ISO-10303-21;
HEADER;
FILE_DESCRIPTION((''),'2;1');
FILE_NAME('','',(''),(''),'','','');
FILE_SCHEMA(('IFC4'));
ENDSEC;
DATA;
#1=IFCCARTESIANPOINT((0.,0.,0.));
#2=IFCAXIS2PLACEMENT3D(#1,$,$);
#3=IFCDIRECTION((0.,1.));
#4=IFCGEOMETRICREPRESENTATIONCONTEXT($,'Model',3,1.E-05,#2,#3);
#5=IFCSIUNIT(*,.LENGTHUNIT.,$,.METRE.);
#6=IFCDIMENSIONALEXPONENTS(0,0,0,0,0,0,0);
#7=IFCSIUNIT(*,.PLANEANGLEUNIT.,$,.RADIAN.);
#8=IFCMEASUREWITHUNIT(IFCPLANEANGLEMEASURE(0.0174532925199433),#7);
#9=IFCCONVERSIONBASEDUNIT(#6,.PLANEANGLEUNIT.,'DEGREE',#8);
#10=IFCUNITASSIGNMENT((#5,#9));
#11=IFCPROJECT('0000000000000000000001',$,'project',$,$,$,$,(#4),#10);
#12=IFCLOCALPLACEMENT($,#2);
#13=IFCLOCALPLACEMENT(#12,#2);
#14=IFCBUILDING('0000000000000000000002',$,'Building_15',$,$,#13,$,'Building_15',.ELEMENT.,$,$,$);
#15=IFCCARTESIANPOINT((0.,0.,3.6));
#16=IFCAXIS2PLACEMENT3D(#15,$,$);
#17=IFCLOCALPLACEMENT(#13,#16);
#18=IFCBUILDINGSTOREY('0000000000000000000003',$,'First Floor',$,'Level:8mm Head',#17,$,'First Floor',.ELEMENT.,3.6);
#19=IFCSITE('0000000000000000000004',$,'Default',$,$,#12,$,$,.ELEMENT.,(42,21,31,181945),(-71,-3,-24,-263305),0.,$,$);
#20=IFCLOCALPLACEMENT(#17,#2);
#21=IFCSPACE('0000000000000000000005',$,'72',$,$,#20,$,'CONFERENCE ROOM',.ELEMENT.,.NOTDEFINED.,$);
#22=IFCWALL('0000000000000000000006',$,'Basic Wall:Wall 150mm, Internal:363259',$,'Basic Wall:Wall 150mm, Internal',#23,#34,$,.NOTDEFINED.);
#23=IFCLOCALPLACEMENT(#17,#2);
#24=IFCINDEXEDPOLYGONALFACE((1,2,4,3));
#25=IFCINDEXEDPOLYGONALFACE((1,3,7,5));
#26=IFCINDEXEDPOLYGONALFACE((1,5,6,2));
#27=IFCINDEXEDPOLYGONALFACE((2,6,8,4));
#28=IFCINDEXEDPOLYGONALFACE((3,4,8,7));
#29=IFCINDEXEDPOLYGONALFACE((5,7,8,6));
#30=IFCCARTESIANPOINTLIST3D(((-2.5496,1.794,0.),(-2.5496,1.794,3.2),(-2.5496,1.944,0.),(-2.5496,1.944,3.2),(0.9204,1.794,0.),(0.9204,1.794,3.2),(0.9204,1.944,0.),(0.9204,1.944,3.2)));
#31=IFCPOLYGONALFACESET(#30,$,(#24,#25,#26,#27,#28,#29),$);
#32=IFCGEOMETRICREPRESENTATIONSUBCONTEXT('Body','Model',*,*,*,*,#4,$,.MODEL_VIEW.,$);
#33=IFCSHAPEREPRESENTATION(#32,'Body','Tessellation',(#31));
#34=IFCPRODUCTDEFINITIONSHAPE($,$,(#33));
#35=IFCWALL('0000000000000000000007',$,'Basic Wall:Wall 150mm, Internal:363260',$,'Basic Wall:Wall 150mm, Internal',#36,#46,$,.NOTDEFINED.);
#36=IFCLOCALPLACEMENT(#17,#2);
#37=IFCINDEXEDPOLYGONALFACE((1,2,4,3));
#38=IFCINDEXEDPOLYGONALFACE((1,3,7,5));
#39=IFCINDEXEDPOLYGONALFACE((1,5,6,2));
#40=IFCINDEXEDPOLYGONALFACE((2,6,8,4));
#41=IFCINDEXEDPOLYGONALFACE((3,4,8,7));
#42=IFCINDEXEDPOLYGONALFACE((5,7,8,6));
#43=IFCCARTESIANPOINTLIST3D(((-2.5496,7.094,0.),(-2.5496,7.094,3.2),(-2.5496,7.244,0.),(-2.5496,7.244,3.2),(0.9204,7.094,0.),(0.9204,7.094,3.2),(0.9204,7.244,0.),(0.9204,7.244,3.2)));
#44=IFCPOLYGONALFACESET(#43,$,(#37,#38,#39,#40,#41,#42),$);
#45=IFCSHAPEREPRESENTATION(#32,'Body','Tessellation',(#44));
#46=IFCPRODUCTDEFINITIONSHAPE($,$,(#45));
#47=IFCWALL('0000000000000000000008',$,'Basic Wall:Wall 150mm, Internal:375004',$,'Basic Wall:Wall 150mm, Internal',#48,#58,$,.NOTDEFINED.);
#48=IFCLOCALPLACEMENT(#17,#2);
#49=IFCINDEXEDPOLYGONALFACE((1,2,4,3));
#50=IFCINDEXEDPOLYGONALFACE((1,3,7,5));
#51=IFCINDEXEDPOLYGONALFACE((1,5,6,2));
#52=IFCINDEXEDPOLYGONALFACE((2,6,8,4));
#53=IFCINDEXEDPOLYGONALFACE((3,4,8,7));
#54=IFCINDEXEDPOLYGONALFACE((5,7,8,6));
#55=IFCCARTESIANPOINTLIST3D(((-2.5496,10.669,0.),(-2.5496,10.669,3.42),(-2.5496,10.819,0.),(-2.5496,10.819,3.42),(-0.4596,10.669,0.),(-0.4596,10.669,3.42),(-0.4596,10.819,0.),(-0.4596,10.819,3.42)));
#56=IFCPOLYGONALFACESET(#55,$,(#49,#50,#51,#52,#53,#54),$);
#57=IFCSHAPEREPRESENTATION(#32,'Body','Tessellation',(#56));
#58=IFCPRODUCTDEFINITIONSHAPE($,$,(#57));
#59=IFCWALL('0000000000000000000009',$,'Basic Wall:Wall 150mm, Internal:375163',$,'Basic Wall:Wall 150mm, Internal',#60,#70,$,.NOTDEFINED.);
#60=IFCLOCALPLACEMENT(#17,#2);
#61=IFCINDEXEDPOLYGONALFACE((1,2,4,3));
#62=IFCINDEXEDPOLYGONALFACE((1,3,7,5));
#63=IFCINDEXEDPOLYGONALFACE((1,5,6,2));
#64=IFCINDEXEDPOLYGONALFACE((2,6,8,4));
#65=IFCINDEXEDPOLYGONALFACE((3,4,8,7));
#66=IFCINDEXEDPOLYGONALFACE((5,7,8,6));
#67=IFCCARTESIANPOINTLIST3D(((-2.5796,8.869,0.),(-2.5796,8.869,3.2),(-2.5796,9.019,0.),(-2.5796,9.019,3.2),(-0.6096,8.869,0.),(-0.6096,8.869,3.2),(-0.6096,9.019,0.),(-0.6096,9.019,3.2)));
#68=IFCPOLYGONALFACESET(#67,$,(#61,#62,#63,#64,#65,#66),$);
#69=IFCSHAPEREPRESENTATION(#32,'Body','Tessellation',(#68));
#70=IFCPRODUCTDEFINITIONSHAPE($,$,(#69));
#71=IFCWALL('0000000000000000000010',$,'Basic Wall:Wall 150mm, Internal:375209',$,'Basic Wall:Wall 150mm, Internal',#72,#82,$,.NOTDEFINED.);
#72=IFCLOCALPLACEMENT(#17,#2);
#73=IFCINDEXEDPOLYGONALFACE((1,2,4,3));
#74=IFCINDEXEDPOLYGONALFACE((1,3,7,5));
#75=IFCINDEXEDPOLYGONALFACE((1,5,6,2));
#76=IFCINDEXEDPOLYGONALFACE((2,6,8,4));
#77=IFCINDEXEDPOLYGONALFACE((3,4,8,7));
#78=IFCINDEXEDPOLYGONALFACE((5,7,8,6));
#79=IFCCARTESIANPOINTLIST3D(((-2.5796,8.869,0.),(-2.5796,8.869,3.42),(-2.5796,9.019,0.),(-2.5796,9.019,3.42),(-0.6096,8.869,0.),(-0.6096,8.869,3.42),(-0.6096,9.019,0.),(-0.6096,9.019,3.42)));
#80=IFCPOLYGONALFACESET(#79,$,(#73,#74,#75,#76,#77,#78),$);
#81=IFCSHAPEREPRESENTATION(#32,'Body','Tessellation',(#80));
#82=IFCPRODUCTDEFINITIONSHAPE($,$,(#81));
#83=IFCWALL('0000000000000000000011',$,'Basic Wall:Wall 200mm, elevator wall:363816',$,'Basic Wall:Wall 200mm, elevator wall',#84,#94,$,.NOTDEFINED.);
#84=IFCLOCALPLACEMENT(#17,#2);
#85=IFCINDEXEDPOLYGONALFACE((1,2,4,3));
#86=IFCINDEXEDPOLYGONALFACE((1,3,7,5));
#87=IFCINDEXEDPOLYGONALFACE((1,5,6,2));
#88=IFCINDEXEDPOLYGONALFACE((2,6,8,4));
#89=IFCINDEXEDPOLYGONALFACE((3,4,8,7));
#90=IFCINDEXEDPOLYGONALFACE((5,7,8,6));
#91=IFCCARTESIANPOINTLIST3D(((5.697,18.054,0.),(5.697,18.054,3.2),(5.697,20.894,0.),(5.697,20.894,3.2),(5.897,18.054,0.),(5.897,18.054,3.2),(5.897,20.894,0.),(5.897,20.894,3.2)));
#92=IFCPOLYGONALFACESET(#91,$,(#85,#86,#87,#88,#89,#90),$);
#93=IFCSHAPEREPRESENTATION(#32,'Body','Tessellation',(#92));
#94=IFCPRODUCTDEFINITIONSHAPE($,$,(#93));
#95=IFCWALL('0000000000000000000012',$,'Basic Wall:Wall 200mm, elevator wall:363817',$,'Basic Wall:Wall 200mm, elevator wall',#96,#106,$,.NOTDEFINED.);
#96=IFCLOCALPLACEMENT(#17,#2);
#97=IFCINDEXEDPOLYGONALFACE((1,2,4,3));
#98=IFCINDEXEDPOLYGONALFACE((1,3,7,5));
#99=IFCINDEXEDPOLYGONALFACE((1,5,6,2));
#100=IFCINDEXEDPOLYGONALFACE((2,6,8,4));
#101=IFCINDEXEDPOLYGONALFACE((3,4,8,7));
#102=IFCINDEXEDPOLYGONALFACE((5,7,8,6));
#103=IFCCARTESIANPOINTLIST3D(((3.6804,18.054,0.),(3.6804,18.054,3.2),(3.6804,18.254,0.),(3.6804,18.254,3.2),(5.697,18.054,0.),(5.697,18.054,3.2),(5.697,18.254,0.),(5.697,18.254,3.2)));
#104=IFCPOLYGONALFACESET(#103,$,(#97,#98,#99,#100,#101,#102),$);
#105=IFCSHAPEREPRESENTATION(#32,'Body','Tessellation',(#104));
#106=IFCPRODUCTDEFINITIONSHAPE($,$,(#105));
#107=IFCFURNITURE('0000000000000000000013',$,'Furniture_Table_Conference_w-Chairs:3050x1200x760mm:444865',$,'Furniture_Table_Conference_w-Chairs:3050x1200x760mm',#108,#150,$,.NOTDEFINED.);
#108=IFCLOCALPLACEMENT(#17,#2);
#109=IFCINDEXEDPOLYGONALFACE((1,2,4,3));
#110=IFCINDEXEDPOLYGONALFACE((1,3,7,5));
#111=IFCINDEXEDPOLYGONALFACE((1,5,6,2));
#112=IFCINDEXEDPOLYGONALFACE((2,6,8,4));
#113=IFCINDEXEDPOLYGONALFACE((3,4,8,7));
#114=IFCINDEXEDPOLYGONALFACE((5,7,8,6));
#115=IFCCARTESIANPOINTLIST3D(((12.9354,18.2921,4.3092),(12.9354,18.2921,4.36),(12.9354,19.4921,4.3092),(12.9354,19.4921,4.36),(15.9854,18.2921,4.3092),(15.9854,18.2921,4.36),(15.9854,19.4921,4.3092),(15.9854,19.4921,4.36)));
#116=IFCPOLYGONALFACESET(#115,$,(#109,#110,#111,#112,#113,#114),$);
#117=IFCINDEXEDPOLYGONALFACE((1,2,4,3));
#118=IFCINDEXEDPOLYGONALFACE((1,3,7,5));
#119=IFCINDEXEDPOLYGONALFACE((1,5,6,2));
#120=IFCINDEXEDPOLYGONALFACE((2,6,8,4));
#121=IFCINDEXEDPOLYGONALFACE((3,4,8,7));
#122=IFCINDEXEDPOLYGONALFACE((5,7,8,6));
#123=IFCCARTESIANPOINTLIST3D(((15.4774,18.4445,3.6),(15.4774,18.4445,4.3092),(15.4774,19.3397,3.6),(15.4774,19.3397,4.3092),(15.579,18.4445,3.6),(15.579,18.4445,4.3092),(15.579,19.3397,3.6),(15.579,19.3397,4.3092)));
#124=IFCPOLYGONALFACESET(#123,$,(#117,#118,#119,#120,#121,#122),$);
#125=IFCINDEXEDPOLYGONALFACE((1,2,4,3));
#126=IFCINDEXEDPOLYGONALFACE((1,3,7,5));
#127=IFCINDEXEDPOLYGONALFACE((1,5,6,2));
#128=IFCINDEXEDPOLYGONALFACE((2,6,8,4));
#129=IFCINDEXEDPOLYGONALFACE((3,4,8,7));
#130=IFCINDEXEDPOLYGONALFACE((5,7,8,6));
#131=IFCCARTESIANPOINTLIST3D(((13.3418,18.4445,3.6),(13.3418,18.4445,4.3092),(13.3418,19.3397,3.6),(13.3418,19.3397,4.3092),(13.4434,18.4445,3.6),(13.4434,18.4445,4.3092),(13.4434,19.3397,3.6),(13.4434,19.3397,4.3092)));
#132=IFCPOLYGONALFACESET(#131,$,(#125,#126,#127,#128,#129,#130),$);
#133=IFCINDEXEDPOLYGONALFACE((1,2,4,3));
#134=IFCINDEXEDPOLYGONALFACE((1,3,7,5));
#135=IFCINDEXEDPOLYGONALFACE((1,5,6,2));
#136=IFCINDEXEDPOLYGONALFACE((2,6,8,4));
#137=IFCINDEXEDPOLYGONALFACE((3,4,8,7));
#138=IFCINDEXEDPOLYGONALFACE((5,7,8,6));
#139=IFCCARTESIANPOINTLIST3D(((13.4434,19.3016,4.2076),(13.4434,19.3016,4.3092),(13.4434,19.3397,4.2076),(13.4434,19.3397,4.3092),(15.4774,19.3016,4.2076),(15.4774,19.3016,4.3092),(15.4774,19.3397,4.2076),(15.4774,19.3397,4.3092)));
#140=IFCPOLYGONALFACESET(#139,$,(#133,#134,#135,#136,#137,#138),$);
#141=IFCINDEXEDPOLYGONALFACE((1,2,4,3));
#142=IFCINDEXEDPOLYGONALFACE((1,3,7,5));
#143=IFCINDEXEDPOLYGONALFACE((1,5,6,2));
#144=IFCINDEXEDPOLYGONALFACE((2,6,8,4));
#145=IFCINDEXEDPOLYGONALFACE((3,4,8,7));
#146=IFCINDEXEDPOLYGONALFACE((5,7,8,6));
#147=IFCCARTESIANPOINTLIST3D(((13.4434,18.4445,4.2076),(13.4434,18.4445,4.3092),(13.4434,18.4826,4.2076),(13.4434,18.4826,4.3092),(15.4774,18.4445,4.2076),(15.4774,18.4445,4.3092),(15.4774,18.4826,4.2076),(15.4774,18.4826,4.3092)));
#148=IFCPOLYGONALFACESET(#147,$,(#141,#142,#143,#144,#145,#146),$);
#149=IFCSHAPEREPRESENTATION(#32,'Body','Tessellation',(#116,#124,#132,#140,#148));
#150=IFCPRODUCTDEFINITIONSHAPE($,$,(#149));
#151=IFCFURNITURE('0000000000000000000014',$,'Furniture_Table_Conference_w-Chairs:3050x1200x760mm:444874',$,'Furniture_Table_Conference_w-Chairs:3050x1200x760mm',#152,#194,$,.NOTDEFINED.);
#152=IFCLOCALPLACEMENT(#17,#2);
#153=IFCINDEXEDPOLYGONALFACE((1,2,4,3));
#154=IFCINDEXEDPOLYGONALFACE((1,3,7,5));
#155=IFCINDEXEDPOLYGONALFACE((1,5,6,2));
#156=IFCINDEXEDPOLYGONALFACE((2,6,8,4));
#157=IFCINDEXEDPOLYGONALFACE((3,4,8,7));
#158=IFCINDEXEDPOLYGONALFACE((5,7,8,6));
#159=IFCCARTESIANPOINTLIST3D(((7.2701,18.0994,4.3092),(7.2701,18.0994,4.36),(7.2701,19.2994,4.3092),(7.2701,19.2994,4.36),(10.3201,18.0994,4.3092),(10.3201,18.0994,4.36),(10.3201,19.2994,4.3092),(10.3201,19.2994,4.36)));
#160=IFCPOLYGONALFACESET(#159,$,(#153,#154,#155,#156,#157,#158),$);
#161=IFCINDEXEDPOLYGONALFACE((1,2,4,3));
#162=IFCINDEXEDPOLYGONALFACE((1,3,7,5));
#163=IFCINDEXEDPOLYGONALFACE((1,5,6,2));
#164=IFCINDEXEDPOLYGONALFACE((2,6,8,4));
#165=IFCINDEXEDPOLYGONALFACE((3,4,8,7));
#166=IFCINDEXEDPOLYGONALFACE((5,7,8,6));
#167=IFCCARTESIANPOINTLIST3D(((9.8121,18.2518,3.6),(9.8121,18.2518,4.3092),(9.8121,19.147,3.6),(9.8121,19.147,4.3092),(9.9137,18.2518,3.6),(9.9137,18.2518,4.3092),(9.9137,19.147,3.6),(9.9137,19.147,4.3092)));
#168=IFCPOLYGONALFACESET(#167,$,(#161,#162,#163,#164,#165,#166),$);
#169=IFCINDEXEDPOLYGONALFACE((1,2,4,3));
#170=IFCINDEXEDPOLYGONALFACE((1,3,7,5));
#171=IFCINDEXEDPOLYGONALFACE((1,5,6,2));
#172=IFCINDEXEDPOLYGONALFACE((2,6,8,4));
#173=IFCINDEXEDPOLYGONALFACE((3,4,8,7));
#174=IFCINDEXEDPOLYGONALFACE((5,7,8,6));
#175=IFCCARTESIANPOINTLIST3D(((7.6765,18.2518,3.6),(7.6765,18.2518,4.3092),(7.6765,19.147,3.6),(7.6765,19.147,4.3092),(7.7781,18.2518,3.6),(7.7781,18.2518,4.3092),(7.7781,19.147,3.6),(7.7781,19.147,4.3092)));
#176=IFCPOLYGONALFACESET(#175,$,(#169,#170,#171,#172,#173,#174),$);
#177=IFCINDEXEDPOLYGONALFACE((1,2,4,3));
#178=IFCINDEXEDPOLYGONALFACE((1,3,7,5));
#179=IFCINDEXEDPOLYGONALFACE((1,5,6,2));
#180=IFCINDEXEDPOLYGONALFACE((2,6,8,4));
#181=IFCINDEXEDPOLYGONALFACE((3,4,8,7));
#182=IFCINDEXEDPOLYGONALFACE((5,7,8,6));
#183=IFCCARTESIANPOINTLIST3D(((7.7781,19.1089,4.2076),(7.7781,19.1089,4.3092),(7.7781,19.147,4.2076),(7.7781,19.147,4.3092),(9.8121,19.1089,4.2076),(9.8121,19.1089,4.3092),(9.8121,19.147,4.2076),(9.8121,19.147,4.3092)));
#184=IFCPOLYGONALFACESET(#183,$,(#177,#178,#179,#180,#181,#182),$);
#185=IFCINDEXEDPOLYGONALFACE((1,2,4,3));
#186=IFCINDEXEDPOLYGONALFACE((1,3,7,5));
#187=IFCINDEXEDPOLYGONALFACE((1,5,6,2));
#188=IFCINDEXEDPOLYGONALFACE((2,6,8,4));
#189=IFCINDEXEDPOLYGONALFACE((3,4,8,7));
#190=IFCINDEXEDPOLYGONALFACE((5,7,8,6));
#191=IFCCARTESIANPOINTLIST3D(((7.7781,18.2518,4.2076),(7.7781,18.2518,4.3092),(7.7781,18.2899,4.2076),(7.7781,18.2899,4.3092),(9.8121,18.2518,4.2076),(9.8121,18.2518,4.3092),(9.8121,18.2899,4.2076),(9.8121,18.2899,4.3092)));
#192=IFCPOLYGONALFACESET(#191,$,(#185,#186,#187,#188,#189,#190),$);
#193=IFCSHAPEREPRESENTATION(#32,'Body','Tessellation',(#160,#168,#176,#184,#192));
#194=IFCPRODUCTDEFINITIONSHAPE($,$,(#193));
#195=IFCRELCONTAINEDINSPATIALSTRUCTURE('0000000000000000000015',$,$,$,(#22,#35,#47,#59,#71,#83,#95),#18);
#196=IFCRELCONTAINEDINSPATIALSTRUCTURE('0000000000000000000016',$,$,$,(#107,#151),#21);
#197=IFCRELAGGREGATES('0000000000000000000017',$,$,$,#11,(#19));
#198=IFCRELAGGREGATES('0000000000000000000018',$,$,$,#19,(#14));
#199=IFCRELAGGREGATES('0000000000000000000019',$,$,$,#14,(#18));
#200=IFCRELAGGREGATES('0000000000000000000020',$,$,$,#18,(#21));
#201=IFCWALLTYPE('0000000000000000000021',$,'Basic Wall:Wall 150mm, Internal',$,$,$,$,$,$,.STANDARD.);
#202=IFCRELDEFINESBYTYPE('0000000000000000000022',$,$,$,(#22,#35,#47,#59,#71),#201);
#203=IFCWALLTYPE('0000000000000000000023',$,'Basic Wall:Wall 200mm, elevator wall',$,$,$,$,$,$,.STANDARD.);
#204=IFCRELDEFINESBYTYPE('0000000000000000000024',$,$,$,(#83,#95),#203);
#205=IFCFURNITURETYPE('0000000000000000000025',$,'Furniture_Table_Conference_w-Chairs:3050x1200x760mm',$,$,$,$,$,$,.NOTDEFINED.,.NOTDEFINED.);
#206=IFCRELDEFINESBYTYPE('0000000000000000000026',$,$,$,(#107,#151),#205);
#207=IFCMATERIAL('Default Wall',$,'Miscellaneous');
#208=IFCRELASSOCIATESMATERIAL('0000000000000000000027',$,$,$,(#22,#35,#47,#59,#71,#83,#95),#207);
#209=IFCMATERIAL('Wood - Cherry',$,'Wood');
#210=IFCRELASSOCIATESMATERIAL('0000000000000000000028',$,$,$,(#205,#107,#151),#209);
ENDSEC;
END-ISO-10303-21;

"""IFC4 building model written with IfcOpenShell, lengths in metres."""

from ifc_helpers import new_model, entity, si_unit, converted_unit, direction, frame, origin, place, context, subcontext, project, spatial, indexed_curve, outline, extrude, source, transform, mapped, material, type_object, type_shapes, element, save


model = new_model("IFC4")

# Units and contexts
model_context = context("Model", 3, precision=1e-05, world=origin(), true_north=direction((0.0, 1.0)))
body_context = subcontext(model_context, "Body", "Model", "MODEL_VIEW")
ifc_project = project(units=[si_unit("LENGTHUNIT", "METRE"), converted_unit("PLANEANGLEUNIT", "DEGREE", entity("IfcPlaneAngleMeasure", 0.0174532925199433), si_unit("PLANEANGLEUNIT", "RADIAN"), dimensions=[0, 0, 0, 0, 0, 0, 0])], contexts=[model_context])

# Site, building, storey
site_placement = place(None, origin())
site = spatial("IfcSite", under=ifc_project, at=site_placement, Name="Default", CompositionType="ELEMENT", RefLatitude=(42, 21, 31, 181945), RefLongitude=(-71, -3, -24, -263305), RefElevation=0.0)
building_placement = place(site_placement, origin())
building = spatial("IfcBuilding", under=site, at=building_placement, Name="Building_15", LongName="Building_15", CompositionType="ELEMENT")
storey_placement = place(building_placement, frame((0.0, 0.0, 3.6)))
storey = spatial("IfcBuildingStorey", under=building, at=storey_placement, Name="First Floor", ObjectType="Level:8mm Head", LongName="First Floor", CompositionType="ELEMENT", Elevation=3.6)

# Walls
ifc_material_1 = material(Name="Default Wall", Category="Miscellaneous")
wall_type_1 = type_object("IfcWallType", Name="Basic Wall:Wall 150mm, Internal", PredefinedType="STANDARD")
wall_1_placement = place(storey_placement, frame((0.9204, 1.869, 0.0), z_axis=(0.0, 0.0, 1.0), x_axis=(-1.0, 0.0, 0.0)))
element("IfcWall", 1, at=wall_1_placement, inside=storey, type_object=wall_type_1, material=ifc_material_1, Name="Basic Wall:Wall 150mm, Internal:363259", ObjectType="Basic Wall:Wall 150mm, Internal", PredefinedType="NOTDEFINED", context=body_context, shape_type="SweptSolid", body=[
    extrude(outline(indexed_curve([(3.47, 0.075), (0.0, 0.075), (0.0, -0.075), (3.47, -0.075), (3.47, 0.075)], self_intersect=False)), origin(), (0.0, 0.0, 1.0), 3.2),
])
wall_2_placement = place(storey_placement, frame((0.9204, 7.169, 0.0), z_axis=(0.0, 0.0, 1.0), x_axis=(-1.0, 0.0, 0.0)))
element("IfcWall", 2, at=wall_2_placement, inside=storey, type_object=wall_type_1, material=ifc_material_1, Name="Basic Wall:Wall 150mm, Internal:363260", ObjectType="Basic Wall:Wall 150mm, Internal", PredefinedType="NOTDEFINED", context=body_context, shape_type="SweptSolid", body=[
    extrude(outline(indexed_curve([(3.47, 0.075), (0.0, 0.075), (0.0, -0.075), (3.47, -0.075), (3.47, 0.075)], self_intersect=False)), origin(), (0.0, 0.0, 1.0), 3.2),
])
wall_3_placement = place(storey_placement, frame((-2.5496, 10.744, 0.0)))
element("IfcWall", 3, at=wall_3_placement, inside=storey, type_object=wall_type_1, material=ifc_material_1, Name="Basic Wall:Wall 150mm, Internal:375004", ObjectType="Basic Wall:Wall 150mm, Internal", PredefinedType="NOTDEFINED", context=body_context, shape_type="SweptSolid", body=[
    extrude(outline(indexed_curve([(2.09, 0.075), (0.0, 0.075), (0.0, -0.075), (2.09, -0.075), (2.09, 0.075)], self_intersect=False)), origin(), (0.0, 0.0, 1.0), 3.42),
])
wall_4_placement = place(storey_placement, frame((-2.5796, 8.944, 0.0)))
element("IfcWall", 4, at=wall_4_placement, inside=storey, type_object=wall_type_1, material=ifc_material_1, Name="Basic Wall:Wall 150mm, Internal:375163", ObjectType="Basic Wall:Wall 150mm, Internal", PredefinedType="NOTDEFINED", context=body_context, shape_type="SweptSolid", body=[
    extrude(outline(indexed_curve([(1.97, 0.075), (0.0, 0.075), (0.0, -0.075), (1.97, -0.075), (1.97, 0.075)], self_intersect=False)), origin(), (0.0, 0.0, 1.0), 3.2),
])
wall_5_placement = place(storey_placement, frame((-2.5796, 8.944, 0.0)))
element("IfcWall", 5, at=wall_5_placement, inside=storey, type_object=wall_type_1, material=ifc_material_1, Name="Basic Wall:Wall 150mm, Internal:375209", ObjectType="Basic Wall:Wall 150mm, Internal", PredefinedType="NOTDEFINED", context=body_context, shape_type="SweptSolid", body=[
    extrude(outline(indexed_curve([(1.97, 0.075), (0.0, 0.075), (0.0, -0.075), (1.97, -0.075), (1.97, 0.075)], self_intersect=False)), origin(), (0.0, 0.0, 1.0), 3.42),
])
wall_type_2 = type_object("IfcWallType", Name="Basic Wall:Wall 200mm, elevator wall", PredefinedType="STANDARD")
wall_6_placement = place(storey_placement, frame((5.797, 20.894, 0.0), z_axis=(0.0, 0.0, 1.0), x_axis=(0.0, -1.0, 0.0)))
element("IfcWall", 6, at=wall_6_placement, inside=storey, type_object=wall_type_2, material=ifc_material_1, Name="Basic Wall:Wall 200mm, elevator wall:363816", ObjectType="Basic Wall:Wall 200mm, elevator wall", PredefinedType="NOTDEFINED", context=body_context, shape_type="SweptSolid", body=[
    extrude(outline(indexed_curve([(2.84, 0.1), (0.0, 0.1), (0.0, -0.1), (2.84, -0.1), (2.84, 0.1)], self_intersect=False)), origin(), (0.0, 0.0, 1.0), 3.2),
])
wall_7_placement = place(storey_placement, frame((5.697, 18.154, 0.0), z_axis=(0.0, 0.0, 1.0), x_axis=(-1.0, 0.0, 0.0)))
element("IfcWall", 7, at=wall_7_placement, inside=storey, type_object=wall_type_2, material=ifc_material_1, Name="Basic Wall:Wall 200mm, elevator wall:363817", ObjectType="Basic Wall:Wall 200mm, elevator wall", PredefinedType="NOTDEFINED", context=body_context, shape_type="SweptSolid", body=[
    extrude(outline(indexed_curve([(2.0166, 0.1), (0.0, 0.1), (0.0, -0.1), (2.0166, -0.1), (2.0166, 0.1)], self_intersect=False)), origin(), (0.0, 0.0, 1.0), 3.2),
])

# Shared definitions
space_1_placement = place(storey_placement, origin())
space_1 = spatial("IfcSpace", under=storey, at=space_1_placement, Name="72", LongName="CONFERENCE ROOM", CompositionType="ELEMENT", PredefinedType="NOTDEFINED")

# Furniture
ifc_material_2 = material(Name="Wood - Cherry", Category="Wood")
furniture_type_1 = type_object("IfcFurnitureType", Name="Furniture_Table_Conference_w-Chairs:3050x1200x760mm", AssemblyPlace="NOTDEFINED", PredefinedType="NOTDEFINED", material=ifc_material_2)
shared_shape_1 = source(origin(), body_context, "Body", "SweptSolid", [
    extrude(outline(indexed_curve([(-0.6, -1.525), (0.6, -1.525), (0.6, 1.525), (-0.6, 1.525), (-0.6, -1.525)], self_intersect=False)), frame((0.0, 0.0, 0.7092), z_axis=(0.0, 0.0, 1.0), x_axis=(0.0, 1.0, 0.0)), (0.0, 0.0, 1.0), 0.0508),
    extrude(outline(indexed_curve([(-0.4476, -0.0508), (0.4476, -0.0508), (0.4476, 0.0508), (-0.4476, 0.0508), (-0.4476, -0.0508)], self_intersect=False)), frame((1.0678, 0.0, 0.0), z_axis=(0.0, 0.0, 1.0), x_axis=(0.0, 1.0, 0.0)), (0.0, 0.0, 1.0), 0.7092),
    extrude(outline(indexed_curve([(-0.4476, -0.0508), (0.4476, -0.0508), (0.4476, 0.0508), (-0.4476, 0.0508), (-0.4476, -0.0508)], self_intersect=False)), frame((-1.0678, 0.0, 0.0), z_axis=(0.0, 0.0, 1.0), x_axis=(0.0, 1.0, 0.0)), (0.0, 0.0, 1.0), 0.7092),
    extrude(outline(indexed_curve([(-1.017, -0.0191), (1.017, -0.0191), (1.017, 0.0191), (-1.017, 0.0191), (-1.017, -0.0191)], self_intersect=False)), frame((0.0, 0.4286, 0.6076), z_axis=(0.0, 0.0, 1.0), x_axis=(-1.0, 0.0, 0.0)), (0.0, 0.0, 1.0), 0.1016),
    extrude(outline(indexed_curve([(-0.019, -1.017), (0.019, -1.017), (0.019, 1.017), (-0.019, 1.017), (-0.019, -1.017)], self_intersect=False)), frame((0.0, -0.4286, 0.6076), z_axis=(0.0, 0.0, 1.0), x_axis=(0.0, 1.0, 0.0)), (0.0, 0.0, 1.0), 0.1016),
])
type_shapes(furniture_type_1, [shared_shape_1])
for number, where, name in (
    (8, (14.4604, 18.8921, 3.6), "Furniture_Table_Conference_w-Chairs:3050x1200x760mm:444865"),
    (9, (8.7951, 18.6994, 3.6), "Furniture_Table_Conference_w-Chairs:3050x1200x760mm:444874"),
):
    element("IfcFurniture", number, at=place(space_1_placement, frame(where)), inside=space_1, type_object=furniture_type_1, material=ifc_material_2, Name=name, ObjectType="Furniture_Table_Conference_w-Chairs:3050x1200x760mm", PredefinedType="NOTDEFINED", context=body_context, shape_type="MappedRepresentation", body=[
        mapped(shared_shape_1, transform((0.0, 0.0, 0.0), scale=1.0)),
    ])

save(model, "model.ifc")
